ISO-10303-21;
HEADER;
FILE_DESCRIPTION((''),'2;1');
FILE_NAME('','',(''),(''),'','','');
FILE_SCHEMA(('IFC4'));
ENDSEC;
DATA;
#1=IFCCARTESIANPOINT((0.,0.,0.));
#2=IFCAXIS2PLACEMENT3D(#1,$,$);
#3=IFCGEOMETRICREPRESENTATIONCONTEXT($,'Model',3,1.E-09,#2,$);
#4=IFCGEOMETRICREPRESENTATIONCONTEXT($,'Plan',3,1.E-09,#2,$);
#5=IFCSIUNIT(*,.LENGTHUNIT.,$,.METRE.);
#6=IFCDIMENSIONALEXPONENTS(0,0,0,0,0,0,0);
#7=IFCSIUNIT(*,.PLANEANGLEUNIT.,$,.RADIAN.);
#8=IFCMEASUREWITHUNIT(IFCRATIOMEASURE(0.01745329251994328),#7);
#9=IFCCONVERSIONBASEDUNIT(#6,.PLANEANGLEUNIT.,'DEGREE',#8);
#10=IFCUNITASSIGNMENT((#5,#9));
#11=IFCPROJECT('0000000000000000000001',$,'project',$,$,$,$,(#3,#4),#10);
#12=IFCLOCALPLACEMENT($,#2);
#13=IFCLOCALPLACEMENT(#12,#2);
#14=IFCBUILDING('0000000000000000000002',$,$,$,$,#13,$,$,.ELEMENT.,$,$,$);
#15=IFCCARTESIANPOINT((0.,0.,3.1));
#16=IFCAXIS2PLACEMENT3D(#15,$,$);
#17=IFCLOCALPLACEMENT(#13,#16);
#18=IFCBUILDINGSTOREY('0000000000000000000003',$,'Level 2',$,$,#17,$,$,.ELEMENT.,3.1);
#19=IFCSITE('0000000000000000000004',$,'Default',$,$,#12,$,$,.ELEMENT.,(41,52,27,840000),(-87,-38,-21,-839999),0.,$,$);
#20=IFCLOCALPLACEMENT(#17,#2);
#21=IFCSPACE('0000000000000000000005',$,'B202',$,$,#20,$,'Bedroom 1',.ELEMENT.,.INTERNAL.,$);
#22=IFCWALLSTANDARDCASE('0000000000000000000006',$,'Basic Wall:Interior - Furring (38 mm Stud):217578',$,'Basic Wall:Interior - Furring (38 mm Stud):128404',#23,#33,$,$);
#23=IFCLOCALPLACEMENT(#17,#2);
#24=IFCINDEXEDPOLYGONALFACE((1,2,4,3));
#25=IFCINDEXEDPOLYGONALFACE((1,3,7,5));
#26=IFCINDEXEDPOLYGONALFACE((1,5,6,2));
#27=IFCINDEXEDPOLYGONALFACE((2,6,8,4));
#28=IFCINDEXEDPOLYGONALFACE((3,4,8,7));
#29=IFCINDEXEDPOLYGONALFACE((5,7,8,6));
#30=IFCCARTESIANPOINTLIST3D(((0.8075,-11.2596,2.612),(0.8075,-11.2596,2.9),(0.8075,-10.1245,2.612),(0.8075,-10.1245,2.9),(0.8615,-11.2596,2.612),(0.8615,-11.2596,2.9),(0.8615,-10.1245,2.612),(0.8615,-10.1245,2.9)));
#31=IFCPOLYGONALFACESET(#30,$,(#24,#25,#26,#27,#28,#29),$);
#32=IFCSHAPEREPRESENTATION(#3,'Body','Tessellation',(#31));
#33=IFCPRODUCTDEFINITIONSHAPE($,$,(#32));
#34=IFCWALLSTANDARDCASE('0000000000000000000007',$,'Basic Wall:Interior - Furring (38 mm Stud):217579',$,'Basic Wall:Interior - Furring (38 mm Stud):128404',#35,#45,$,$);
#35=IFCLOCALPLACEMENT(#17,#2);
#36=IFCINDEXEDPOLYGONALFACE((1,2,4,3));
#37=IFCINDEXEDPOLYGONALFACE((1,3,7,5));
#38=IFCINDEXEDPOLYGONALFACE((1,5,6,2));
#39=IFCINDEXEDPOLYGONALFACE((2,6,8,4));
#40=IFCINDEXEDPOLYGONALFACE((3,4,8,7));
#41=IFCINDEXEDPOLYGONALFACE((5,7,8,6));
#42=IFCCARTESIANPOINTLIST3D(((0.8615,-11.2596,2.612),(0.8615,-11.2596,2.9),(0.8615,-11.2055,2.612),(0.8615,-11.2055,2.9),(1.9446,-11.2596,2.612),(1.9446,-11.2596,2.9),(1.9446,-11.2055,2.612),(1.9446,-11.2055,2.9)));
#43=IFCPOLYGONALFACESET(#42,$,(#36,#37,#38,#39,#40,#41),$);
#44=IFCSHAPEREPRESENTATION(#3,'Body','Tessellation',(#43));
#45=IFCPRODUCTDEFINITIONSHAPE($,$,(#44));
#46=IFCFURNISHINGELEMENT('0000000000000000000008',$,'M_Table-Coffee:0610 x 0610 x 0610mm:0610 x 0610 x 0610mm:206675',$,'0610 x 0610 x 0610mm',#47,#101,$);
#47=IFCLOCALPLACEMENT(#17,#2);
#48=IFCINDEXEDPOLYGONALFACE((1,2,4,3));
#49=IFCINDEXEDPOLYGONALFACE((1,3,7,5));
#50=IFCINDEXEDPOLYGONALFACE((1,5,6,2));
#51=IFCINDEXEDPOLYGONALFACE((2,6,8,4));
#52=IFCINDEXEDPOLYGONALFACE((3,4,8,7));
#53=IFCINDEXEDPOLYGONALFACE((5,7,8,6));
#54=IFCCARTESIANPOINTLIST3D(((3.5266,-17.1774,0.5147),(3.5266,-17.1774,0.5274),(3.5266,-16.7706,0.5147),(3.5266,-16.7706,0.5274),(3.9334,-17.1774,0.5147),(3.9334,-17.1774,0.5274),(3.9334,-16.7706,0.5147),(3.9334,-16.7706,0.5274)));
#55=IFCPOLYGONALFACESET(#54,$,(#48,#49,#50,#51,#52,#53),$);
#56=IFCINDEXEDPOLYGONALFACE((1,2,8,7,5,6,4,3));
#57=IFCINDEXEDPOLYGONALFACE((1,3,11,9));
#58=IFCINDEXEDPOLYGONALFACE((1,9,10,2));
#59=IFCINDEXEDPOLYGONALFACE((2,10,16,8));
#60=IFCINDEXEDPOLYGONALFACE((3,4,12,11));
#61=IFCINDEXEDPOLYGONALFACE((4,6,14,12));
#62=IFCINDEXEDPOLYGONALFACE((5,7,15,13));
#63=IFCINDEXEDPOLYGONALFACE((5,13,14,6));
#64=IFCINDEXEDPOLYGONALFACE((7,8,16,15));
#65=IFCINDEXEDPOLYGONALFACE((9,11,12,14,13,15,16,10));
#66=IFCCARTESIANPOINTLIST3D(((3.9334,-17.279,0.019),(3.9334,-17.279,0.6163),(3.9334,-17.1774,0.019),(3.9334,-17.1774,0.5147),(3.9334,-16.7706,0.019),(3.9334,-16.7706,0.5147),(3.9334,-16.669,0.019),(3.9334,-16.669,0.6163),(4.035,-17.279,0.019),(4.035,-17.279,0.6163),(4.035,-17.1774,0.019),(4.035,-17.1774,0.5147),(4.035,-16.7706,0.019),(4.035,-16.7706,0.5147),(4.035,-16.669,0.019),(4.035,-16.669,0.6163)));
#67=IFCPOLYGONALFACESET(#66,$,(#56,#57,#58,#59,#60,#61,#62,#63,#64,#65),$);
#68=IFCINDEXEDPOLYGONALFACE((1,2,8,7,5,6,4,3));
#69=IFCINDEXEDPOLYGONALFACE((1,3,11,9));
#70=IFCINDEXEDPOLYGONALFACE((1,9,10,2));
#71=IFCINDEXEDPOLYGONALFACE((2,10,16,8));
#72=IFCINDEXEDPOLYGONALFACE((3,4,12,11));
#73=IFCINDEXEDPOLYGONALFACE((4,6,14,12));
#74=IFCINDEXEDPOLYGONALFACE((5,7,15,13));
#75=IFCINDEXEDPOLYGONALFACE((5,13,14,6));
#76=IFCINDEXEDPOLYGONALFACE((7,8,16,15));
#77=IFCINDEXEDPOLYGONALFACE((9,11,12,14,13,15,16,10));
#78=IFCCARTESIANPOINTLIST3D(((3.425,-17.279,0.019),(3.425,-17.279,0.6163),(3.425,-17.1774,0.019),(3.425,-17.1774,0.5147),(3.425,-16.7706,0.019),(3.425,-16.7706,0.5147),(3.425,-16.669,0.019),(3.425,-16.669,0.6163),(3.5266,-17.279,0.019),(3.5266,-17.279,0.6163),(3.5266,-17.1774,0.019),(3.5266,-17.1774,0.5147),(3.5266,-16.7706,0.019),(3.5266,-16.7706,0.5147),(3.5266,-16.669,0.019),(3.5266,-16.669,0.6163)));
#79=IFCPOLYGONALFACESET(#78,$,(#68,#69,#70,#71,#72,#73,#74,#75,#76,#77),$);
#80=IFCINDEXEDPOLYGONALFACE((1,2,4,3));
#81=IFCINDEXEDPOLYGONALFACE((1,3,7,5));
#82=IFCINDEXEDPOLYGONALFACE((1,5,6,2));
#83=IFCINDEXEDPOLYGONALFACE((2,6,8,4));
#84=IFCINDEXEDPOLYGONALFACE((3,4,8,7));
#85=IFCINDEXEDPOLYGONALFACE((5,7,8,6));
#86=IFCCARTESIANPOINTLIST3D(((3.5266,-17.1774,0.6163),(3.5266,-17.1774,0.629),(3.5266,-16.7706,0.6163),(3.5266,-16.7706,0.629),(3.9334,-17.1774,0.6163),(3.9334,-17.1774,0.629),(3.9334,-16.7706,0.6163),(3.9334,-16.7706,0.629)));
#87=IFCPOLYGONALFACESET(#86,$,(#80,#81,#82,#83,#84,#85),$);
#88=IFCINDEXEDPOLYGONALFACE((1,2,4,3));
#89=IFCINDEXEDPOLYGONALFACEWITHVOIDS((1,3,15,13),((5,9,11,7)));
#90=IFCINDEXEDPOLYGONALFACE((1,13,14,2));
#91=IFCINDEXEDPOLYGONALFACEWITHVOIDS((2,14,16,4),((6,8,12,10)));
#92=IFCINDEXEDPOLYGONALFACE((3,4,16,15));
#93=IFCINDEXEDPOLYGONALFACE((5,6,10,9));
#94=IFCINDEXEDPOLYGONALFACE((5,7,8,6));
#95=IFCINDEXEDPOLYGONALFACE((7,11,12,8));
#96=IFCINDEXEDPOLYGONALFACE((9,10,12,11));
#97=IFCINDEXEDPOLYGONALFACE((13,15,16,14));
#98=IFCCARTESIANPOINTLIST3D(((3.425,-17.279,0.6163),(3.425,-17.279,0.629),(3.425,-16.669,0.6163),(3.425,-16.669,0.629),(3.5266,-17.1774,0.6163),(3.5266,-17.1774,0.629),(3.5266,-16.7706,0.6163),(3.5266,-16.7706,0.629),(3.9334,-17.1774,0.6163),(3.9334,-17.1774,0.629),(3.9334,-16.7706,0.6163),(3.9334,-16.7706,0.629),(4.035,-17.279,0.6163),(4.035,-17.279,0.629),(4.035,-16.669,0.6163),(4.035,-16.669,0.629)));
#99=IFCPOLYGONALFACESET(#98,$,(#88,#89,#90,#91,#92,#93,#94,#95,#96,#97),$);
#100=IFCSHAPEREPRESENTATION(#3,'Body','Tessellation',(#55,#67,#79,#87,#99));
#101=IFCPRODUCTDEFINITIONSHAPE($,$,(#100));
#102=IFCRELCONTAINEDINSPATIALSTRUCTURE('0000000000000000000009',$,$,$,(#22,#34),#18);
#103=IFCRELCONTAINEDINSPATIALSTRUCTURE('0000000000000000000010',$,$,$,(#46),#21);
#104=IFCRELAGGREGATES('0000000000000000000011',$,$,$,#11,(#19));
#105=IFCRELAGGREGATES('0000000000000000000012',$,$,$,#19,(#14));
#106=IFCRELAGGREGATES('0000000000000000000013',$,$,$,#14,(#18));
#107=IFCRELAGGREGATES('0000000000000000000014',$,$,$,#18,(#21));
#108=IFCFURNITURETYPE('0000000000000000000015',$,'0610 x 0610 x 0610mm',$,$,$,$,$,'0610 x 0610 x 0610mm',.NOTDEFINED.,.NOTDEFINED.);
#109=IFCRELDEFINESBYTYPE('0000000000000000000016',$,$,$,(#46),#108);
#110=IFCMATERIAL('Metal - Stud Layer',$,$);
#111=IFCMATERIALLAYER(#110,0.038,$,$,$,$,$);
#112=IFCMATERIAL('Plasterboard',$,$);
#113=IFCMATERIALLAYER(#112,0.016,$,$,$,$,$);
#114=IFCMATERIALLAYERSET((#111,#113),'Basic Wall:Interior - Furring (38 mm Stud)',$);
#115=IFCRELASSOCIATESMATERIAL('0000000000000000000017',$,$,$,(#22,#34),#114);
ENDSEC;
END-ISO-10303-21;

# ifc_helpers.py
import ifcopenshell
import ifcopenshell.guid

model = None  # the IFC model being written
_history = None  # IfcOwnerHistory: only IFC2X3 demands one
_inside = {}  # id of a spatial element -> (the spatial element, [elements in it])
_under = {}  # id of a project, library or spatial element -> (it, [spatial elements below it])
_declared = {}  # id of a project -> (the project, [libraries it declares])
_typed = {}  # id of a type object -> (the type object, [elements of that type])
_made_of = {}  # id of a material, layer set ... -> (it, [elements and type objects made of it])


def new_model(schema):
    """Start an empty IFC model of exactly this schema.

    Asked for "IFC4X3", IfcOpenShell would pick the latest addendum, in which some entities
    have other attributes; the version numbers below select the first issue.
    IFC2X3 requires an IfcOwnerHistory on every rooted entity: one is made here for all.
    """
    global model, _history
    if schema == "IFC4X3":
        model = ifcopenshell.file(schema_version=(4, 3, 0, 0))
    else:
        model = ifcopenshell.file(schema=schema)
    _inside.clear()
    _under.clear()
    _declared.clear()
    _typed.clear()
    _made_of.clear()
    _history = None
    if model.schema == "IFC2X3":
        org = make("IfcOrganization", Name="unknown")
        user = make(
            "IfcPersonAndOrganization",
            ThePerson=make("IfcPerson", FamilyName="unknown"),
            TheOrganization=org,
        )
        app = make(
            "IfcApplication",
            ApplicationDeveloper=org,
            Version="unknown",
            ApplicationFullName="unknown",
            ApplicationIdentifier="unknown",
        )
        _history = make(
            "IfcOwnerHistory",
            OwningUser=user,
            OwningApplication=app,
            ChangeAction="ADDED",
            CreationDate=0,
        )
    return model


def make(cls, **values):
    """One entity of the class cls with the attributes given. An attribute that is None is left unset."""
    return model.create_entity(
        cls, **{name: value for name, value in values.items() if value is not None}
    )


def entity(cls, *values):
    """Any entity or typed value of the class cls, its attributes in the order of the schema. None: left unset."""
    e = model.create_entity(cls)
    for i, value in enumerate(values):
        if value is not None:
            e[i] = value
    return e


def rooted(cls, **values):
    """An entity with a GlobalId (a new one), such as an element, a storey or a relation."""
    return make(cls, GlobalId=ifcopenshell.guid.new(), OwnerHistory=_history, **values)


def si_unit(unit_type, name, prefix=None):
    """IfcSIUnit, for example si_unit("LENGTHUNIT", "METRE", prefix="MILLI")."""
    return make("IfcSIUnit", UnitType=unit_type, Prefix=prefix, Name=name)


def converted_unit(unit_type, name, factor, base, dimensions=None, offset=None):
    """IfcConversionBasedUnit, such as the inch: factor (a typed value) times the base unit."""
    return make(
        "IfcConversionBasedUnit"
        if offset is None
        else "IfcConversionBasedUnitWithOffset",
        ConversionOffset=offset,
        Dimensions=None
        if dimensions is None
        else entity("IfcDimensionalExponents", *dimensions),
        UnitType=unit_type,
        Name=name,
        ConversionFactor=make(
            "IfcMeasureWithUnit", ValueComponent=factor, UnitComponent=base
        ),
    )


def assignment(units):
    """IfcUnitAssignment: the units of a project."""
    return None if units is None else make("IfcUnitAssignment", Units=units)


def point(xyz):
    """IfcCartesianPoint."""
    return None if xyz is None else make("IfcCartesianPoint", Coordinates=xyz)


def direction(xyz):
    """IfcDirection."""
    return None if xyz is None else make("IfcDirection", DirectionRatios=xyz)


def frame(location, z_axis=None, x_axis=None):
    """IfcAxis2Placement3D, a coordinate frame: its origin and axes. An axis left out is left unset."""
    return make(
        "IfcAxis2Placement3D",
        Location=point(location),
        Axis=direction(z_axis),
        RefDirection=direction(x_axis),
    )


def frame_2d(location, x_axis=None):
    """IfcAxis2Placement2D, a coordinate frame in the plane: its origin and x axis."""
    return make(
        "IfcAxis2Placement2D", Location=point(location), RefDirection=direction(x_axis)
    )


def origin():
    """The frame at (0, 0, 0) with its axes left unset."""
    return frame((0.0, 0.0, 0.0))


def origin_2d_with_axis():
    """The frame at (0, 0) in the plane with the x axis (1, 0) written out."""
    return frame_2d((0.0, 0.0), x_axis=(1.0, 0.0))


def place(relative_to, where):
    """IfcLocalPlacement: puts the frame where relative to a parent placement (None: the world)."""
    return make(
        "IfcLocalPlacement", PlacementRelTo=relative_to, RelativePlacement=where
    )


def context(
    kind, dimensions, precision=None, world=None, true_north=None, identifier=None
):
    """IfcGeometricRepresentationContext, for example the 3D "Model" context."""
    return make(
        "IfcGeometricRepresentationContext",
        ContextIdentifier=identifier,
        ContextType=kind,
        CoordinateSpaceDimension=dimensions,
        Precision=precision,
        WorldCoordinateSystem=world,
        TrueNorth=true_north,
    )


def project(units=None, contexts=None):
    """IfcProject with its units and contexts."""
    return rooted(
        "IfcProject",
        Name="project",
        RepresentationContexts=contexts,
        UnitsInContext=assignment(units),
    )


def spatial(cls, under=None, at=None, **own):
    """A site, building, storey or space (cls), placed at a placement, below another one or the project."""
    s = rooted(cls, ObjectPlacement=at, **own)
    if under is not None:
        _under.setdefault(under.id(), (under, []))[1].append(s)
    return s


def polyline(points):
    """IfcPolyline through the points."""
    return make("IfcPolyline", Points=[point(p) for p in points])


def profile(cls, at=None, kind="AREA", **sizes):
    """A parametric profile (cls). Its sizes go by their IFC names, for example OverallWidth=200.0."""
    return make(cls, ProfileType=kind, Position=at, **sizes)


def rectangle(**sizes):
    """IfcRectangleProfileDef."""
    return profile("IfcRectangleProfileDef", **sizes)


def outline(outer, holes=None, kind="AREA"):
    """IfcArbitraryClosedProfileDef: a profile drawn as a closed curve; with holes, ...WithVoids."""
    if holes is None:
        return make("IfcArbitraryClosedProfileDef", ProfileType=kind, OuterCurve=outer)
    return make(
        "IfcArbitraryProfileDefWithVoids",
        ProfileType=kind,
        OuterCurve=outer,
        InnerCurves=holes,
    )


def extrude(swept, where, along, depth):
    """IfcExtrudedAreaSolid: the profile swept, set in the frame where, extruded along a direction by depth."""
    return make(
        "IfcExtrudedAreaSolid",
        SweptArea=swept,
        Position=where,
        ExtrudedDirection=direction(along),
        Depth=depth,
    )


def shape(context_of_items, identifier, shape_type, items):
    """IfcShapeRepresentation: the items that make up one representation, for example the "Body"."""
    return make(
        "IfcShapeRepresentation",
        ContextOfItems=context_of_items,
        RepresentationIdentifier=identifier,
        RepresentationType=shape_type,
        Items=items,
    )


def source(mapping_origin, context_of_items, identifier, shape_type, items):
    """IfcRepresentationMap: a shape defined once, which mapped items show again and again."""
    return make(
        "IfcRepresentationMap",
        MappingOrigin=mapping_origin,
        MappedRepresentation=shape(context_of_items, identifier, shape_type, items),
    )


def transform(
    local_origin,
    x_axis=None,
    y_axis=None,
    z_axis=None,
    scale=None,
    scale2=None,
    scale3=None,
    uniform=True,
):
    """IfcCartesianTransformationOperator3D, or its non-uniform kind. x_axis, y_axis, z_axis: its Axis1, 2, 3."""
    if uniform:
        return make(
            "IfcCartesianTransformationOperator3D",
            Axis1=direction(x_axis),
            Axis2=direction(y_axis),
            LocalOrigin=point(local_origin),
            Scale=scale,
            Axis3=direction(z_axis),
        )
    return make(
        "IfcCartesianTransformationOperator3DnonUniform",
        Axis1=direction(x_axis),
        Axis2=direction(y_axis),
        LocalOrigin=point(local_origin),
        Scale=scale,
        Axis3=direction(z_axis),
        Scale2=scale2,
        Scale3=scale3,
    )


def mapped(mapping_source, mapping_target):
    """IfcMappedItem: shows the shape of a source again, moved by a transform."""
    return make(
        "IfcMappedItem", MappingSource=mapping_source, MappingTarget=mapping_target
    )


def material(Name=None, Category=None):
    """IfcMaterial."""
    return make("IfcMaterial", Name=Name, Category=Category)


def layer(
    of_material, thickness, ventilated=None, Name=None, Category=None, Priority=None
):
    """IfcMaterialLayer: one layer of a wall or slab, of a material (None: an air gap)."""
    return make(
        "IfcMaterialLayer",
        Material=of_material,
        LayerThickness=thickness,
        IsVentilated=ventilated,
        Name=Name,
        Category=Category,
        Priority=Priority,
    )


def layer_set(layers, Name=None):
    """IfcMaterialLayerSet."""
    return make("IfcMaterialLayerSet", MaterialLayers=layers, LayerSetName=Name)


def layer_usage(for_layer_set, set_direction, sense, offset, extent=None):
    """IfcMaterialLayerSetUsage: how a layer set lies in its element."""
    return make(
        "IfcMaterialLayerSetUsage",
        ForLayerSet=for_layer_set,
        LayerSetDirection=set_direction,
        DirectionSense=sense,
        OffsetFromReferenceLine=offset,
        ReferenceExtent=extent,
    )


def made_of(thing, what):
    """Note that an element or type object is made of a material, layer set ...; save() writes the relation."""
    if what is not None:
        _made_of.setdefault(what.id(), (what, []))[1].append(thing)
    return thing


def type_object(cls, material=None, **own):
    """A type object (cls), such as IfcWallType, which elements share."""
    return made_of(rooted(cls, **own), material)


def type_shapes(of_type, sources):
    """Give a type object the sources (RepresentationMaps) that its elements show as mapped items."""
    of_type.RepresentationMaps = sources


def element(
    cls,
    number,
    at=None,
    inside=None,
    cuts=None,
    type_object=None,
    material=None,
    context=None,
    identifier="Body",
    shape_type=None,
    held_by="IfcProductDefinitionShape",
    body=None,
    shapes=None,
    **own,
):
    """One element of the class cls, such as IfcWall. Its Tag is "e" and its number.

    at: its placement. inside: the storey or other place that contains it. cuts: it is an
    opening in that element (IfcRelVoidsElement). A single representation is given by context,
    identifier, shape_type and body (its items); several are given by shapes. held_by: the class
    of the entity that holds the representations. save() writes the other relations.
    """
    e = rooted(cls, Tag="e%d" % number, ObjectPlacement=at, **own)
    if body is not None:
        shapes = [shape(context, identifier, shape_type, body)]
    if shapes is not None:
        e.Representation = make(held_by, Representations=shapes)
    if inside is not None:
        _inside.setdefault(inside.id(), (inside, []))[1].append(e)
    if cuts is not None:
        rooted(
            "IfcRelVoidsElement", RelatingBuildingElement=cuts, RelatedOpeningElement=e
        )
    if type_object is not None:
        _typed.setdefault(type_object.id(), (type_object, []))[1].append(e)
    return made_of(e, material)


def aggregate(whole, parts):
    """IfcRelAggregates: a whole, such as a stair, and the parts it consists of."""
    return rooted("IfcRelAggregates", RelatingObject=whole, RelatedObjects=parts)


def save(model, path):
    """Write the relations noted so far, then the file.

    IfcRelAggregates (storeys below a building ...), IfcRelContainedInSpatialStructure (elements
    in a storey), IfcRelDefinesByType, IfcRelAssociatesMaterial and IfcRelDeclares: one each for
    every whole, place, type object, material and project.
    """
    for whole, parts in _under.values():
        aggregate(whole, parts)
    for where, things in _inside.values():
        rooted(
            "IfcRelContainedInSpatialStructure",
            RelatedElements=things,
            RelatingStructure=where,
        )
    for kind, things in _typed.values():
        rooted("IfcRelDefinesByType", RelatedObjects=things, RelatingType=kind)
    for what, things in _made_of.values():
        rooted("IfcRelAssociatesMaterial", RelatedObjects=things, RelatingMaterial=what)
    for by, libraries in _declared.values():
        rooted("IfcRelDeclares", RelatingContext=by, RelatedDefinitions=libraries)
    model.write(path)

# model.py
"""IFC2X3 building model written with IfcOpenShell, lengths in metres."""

from ifc_helpers import new_model, entity, si_unit, converted_unit, frame, frame_2d, origin, origin_2d_with_axis, place, context, project, spatial, polyline, rectangle, outline, extrude, source, transform, mapped, material, layer, layer_set, layer_usage, type_object, type_shapes, element, save


model = new_model("IFC2X3")

# Units and contexts
model_context = context("Model", 3, precision=1e-09, world=origin())
plan_context = context("Plan", 3, precision=1e-09, world=origin())
ifc_project = project(units=[si_unit("LENGTHUNIT", "METRE"), converted_unit("PLANEANGLEUNIT", "DEGREE", entity("IfcRatioMeasure", 0.01745329251994328), si_unit("PLANEANGLEUNIT", "RADIAN"), dimensions=[0, 0, 0, 0, 0, 0, 0])], contexts=[model_context, plan_context])

# Site, building, storey
site_placement = place(None, origin())
site = spatial("IfcSite", under=ifc_project, at=site_placement, Name="Default", CompositionType="ELEMENT", RefLatitude=(41, 52, 27, 840000), RefLongitude=(-87, -38, -21, -839999), RefElevation=0.0)
building_placement = place(site_placement, origin())
building = spatial("IfcBuilding", under=site, at=building_placement, CompositionType="ELEMENT")
storey_placement = place(building_placement, frame((0.0, 0.0, 3.1)))
storey = spatial("IfcBuildingStorey", under=building, at=storey_placement, Name="Level 2", CompositionType="ELEMENT", Elevation=3.1)

# Shared definitions
ifc_material_1 = material(Name="Metal - Stud Layer")
ifc_material_2 = material(Name="Plasterboard")
ifc_layer_1 = layer(ifc_material_2, 0.016)

# Walls
ifc_layer_2 = layer(ifc_material_1, 0.038)
ifc_layer_set_1 = layer_set([ifc_layer_2, ifc_layer_1], Name="Basic Wall:Interior - Furring (38 mm Stud)")
ifc_layer_usage_1 = layer_usage(ifc_layer_set_1, "AXIS2", "NEGATIVE", 0.027)
wall_1_placement = place(storey_placement, frame((0.8345, -11.2596, 2.612), z_axis=(0.0, 0.0, 1.0), x_axis=(0.0, 1.0, 0.0)))
element("IfcWallStandardCase", 1, at=wall_1_placement, inside=storey, material=ifc_layer_usage_1, Name="Basic Wall:Interior - Furring (38 mm Stud):217578", ObjectType="Basic Wall:Interior - Furring (38 mm Stud):128404", context=model_context, shape_type="SweptSolid", body=[
    extrude(rectangle(XDim=1.1351, YDim=0.054, at=frame_2d((0.5675, 0.0), x_axis=(-1.0, 0.0))), origin(), (0.0, 0.0, 1.0), 0.288),
])
wall_2_placement = place(storey_placement, frame((1.9446, -11.2325, 2.612), z_axis=(0.0, 0.0, 1.0), x_axis=(-1.0, 0.0, 0.0)))
element("IfcWallStandardCase", 2, at=wall_2_placement, inside=storey, material=ifc_layer_usage_1, Name="Basic Wall:Interior - Furring (38 mm Stud):217579", ObjectType="Basic Wall:Interior - Furring (38 mm Stud):128404", context=model_context, shape_type="SweptSolid", body=[
    extrude(rectangle(XDim=1.0831, YDim=0.054, at=frame_2d((0.5415, 0.0), x_axis=(-1.0, 0.0))), origin(), (0.0, 0.0, 1.0), 0.288),
])

# Shared definitions
space_placement = place(storey_placement, origin())
space = spatial("IfcSpace", under=storey, at=space_placement, Name="B202", LongName="Bedroom 1", CompositionType="ELEMENT", InteriorOrExteriorSpace="INTERNAL")

# Furnishing element
furniture_type = type_object("IfcFurnitureType", Name="0610 x 0610 x 0610mm", ElementType="0610 x 0610 x 0610mm", AssemblyPlace="NOTDEFINED")
shared_shape_1 = source(origin(), model_context, "Body", "SweptSolid", [
    extrude(rectangle(XDim=0.4068, YDim=0.4068, at=origin_2d_with_axis()), frame((0.0183, 0.0952, 0.4957), z_axis=(0.0, 0.0, 1.0), x_axis=(-1.0, 0.0, 0.0)), (0.0, 0.0, 1.0), 0.0127),
    extrude(outline(polyline([(-0.2732, -0.305), (0.324, -0.305), (0.324, 0.305), (-0.2732, 0.305), (-0.2732, 0.2034), (0.2225, 0.2034), (0.2225, -0.2034), (-0.2732, -0.2034), (-0.2732, -0.305)])), frame((0.2217, 0.0952, 0.2732), z_axis=(1.0, 0.0, 0.0), x_axis=(0.0, 0.0, 1.0)), (0.0, 0.0, 1.0), 0.1016),
    extrude(outline(polyline([(-0.305, -0.3241), (0.305, -0.3241), (0.305, 0.2733), (0.2034, 0.2733), (0.2034, -0.2224), (-0.2034, -0.2224), (-0.2034, 0.2733), (-0.305, 0.2733), (-0.305, -0.3241)])), frame((-0.2867, 0.0952, 0.2733), z_axis=(1.0, 0.0, 0.0), x_axis=(0.0, -1.0, 0.0)), (0.0, 0.0, 1.0), 0.1016),
    extrude(rectangle(XDim=0.4068, YDim=0.4068, at=origin_2d_with_axis()), frame((0.0183, 0.0952, 0.5973), z_axis=(0.0, 0.0, 1.0), x_axis=(-1.0, 0.0, 0.0)), (0.0, 0.0, 1.0), 0.0127),
    extrude(outline(polyline([(-0.305, -0.305), (0.305, -0.305), (0.305, 0.305), (-0.305, 0.305), (-0.305, -0.305)]), holes=[polyline([(-0.2034, -0.2034), (-0.2034, 0.2034), (0.2034, 0.2034), (0.2034, -0.2034), (-0.2034, -0.2034)])]), frame((0.0183, 0.0952, 0.5973), z_axis=(0.0, 0.0, 1.0), x_axis=(-1.0, 0.0, 0.0)), (0.0, 0.0, 1.0), 0.0127),
])
type_shapes(furniture_type, [shared_shape_1])
furnishing_placement = place(space_placement, frame((3.7117, -17.0692, 0.019)))
element("IfcFurnishingElement", 3, at=furnishing_placement, inside=space, type_object=furniture_type, Name="M_Table-Coffee:0610 x 0610 x 0610mm:0610 x 0610 x 0610mm:206675", ObjectType="0610 x 0610 x 0610mm", context=model_context, shape_type="MappedRepresentation", body=[
    mapped(shared_shape_1, transform((0.0, 0.0, 0.0), scale=1.0)),
])

save(model, "model.ifc")
